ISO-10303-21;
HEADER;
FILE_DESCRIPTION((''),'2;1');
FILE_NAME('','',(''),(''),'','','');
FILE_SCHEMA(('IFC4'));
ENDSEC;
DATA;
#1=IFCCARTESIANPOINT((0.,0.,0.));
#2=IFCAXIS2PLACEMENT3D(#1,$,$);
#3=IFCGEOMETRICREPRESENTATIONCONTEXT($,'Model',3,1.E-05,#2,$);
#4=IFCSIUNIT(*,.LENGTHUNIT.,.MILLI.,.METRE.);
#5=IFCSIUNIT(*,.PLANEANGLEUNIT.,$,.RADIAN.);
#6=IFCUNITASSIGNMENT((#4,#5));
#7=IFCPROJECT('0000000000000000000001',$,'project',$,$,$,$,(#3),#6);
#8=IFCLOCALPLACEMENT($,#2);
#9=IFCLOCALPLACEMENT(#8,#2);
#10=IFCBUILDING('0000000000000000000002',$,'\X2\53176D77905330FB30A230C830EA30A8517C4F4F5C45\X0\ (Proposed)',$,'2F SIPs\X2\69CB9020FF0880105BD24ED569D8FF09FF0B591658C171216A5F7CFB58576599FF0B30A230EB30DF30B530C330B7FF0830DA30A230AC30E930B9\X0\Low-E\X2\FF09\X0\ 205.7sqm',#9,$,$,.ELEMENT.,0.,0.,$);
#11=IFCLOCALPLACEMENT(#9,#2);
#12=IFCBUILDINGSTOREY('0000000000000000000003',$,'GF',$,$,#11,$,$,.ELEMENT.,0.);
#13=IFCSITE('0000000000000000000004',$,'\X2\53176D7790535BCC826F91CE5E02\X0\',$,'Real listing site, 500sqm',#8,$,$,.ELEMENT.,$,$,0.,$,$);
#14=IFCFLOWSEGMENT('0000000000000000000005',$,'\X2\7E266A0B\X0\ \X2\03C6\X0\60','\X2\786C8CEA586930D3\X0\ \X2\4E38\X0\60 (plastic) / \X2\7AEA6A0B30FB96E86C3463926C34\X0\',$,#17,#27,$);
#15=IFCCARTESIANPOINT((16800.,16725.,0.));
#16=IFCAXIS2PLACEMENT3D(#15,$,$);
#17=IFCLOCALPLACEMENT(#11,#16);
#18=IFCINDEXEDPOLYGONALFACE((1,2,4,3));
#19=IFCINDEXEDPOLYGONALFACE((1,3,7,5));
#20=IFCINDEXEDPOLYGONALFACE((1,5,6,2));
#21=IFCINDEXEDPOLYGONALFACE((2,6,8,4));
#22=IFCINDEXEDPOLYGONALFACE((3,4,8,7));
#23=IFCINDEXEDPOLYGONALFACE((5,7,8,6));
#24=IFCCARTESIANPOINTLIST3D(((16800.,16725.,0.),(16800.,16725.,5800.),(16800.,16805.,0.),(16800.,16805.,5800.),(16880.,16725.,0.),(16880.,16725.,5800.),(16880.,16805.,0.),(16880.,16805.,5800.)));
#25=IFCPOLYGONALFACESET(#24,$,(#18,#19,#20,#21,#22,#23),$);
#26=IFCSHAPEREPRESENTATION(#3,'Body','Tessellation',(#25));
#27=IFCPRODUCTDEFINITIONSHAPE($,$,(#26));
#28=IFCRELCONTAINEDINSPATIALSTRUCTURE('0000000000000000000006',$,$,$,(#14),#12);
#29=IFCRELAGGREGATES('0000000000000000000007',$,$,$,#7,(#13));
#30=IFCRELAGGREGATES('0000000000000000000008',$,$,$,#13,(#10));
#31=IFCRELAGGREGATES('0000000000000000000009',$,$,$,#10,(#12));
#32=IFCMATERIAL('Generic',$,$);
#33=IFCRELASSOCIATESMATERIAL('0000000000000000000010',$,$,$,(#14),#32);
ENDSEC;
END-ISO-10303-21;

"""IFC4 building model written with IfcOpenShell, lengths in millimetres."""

from ifc_helpers import new_model, si_unit, frame, frame_2d, origin, place, context, project, spatial, rectangle, extrude, material, element, save


model = new_model("IFC4")

# Units and contexts
model_context = context("Model", 3, precision=1e-05, world=origin())
ifc_project = project(units=[si_unit("LENGTHUNIT", "METRE", prefix="MILLI"), si_unit("PLANEANGLEUNIT", "RADIAN")], contexts=[model_context])

# Site, building, storey
site_placement = place(None, origin())
site = spatial("IfcSite", under=ifc_project, at=site_placement, Name="北海道富良野市", ObjectType="Real listing site, 500sqm", CompositionType="ELEMENT", RefElevation=0.0)
building_placement = place(site_placement, origin())
building = spatial("IfcBuilding", under=site, at=building_placement, Name="北海道・アトリエ兼住居 (Proposed)", ObjectType="2F SIPs構造（耐寒仕様）＋外壁無機系塗料＋アルミサッシ（ペアガラスLow-E） 205.7sqm", CompositionType="ELEMENT", ElevationOfRefHeight=0.0, ElevationOfTerrain=0.0)
storey_placement = place(building_placement, origin())
storey = spatial("IfcBuildingStorey", under=building, at=storey_placement, Name="GF", CompositionType="ELEMENT", Elevation=0.0)

# Flow segment
ifc_material_1 = material(Name="Generic")
flow_segment_placement = place(storey_placement, frame((16800.0, 16725.0, 0.0)))
element("IfcFlowSegment", 1, at=flow_segment_placement, inside=storey, material=ifc_material_1, Name="縦樋 φ60", Description="硬質塩ビ 丸60 (plastic) / 竪樋・雨水排水", context=model_context, shape_type="SweptSolid", body=[
    extrude(rectangle(XDim=80.0, YDim=80.0, at=frame_2d((40.0, 40.0))), frame((16800.0, 16725.0, 0.0)), (0.0, 0.0, 1.0), 5800.0),
])

save(model, "model.ifc")
